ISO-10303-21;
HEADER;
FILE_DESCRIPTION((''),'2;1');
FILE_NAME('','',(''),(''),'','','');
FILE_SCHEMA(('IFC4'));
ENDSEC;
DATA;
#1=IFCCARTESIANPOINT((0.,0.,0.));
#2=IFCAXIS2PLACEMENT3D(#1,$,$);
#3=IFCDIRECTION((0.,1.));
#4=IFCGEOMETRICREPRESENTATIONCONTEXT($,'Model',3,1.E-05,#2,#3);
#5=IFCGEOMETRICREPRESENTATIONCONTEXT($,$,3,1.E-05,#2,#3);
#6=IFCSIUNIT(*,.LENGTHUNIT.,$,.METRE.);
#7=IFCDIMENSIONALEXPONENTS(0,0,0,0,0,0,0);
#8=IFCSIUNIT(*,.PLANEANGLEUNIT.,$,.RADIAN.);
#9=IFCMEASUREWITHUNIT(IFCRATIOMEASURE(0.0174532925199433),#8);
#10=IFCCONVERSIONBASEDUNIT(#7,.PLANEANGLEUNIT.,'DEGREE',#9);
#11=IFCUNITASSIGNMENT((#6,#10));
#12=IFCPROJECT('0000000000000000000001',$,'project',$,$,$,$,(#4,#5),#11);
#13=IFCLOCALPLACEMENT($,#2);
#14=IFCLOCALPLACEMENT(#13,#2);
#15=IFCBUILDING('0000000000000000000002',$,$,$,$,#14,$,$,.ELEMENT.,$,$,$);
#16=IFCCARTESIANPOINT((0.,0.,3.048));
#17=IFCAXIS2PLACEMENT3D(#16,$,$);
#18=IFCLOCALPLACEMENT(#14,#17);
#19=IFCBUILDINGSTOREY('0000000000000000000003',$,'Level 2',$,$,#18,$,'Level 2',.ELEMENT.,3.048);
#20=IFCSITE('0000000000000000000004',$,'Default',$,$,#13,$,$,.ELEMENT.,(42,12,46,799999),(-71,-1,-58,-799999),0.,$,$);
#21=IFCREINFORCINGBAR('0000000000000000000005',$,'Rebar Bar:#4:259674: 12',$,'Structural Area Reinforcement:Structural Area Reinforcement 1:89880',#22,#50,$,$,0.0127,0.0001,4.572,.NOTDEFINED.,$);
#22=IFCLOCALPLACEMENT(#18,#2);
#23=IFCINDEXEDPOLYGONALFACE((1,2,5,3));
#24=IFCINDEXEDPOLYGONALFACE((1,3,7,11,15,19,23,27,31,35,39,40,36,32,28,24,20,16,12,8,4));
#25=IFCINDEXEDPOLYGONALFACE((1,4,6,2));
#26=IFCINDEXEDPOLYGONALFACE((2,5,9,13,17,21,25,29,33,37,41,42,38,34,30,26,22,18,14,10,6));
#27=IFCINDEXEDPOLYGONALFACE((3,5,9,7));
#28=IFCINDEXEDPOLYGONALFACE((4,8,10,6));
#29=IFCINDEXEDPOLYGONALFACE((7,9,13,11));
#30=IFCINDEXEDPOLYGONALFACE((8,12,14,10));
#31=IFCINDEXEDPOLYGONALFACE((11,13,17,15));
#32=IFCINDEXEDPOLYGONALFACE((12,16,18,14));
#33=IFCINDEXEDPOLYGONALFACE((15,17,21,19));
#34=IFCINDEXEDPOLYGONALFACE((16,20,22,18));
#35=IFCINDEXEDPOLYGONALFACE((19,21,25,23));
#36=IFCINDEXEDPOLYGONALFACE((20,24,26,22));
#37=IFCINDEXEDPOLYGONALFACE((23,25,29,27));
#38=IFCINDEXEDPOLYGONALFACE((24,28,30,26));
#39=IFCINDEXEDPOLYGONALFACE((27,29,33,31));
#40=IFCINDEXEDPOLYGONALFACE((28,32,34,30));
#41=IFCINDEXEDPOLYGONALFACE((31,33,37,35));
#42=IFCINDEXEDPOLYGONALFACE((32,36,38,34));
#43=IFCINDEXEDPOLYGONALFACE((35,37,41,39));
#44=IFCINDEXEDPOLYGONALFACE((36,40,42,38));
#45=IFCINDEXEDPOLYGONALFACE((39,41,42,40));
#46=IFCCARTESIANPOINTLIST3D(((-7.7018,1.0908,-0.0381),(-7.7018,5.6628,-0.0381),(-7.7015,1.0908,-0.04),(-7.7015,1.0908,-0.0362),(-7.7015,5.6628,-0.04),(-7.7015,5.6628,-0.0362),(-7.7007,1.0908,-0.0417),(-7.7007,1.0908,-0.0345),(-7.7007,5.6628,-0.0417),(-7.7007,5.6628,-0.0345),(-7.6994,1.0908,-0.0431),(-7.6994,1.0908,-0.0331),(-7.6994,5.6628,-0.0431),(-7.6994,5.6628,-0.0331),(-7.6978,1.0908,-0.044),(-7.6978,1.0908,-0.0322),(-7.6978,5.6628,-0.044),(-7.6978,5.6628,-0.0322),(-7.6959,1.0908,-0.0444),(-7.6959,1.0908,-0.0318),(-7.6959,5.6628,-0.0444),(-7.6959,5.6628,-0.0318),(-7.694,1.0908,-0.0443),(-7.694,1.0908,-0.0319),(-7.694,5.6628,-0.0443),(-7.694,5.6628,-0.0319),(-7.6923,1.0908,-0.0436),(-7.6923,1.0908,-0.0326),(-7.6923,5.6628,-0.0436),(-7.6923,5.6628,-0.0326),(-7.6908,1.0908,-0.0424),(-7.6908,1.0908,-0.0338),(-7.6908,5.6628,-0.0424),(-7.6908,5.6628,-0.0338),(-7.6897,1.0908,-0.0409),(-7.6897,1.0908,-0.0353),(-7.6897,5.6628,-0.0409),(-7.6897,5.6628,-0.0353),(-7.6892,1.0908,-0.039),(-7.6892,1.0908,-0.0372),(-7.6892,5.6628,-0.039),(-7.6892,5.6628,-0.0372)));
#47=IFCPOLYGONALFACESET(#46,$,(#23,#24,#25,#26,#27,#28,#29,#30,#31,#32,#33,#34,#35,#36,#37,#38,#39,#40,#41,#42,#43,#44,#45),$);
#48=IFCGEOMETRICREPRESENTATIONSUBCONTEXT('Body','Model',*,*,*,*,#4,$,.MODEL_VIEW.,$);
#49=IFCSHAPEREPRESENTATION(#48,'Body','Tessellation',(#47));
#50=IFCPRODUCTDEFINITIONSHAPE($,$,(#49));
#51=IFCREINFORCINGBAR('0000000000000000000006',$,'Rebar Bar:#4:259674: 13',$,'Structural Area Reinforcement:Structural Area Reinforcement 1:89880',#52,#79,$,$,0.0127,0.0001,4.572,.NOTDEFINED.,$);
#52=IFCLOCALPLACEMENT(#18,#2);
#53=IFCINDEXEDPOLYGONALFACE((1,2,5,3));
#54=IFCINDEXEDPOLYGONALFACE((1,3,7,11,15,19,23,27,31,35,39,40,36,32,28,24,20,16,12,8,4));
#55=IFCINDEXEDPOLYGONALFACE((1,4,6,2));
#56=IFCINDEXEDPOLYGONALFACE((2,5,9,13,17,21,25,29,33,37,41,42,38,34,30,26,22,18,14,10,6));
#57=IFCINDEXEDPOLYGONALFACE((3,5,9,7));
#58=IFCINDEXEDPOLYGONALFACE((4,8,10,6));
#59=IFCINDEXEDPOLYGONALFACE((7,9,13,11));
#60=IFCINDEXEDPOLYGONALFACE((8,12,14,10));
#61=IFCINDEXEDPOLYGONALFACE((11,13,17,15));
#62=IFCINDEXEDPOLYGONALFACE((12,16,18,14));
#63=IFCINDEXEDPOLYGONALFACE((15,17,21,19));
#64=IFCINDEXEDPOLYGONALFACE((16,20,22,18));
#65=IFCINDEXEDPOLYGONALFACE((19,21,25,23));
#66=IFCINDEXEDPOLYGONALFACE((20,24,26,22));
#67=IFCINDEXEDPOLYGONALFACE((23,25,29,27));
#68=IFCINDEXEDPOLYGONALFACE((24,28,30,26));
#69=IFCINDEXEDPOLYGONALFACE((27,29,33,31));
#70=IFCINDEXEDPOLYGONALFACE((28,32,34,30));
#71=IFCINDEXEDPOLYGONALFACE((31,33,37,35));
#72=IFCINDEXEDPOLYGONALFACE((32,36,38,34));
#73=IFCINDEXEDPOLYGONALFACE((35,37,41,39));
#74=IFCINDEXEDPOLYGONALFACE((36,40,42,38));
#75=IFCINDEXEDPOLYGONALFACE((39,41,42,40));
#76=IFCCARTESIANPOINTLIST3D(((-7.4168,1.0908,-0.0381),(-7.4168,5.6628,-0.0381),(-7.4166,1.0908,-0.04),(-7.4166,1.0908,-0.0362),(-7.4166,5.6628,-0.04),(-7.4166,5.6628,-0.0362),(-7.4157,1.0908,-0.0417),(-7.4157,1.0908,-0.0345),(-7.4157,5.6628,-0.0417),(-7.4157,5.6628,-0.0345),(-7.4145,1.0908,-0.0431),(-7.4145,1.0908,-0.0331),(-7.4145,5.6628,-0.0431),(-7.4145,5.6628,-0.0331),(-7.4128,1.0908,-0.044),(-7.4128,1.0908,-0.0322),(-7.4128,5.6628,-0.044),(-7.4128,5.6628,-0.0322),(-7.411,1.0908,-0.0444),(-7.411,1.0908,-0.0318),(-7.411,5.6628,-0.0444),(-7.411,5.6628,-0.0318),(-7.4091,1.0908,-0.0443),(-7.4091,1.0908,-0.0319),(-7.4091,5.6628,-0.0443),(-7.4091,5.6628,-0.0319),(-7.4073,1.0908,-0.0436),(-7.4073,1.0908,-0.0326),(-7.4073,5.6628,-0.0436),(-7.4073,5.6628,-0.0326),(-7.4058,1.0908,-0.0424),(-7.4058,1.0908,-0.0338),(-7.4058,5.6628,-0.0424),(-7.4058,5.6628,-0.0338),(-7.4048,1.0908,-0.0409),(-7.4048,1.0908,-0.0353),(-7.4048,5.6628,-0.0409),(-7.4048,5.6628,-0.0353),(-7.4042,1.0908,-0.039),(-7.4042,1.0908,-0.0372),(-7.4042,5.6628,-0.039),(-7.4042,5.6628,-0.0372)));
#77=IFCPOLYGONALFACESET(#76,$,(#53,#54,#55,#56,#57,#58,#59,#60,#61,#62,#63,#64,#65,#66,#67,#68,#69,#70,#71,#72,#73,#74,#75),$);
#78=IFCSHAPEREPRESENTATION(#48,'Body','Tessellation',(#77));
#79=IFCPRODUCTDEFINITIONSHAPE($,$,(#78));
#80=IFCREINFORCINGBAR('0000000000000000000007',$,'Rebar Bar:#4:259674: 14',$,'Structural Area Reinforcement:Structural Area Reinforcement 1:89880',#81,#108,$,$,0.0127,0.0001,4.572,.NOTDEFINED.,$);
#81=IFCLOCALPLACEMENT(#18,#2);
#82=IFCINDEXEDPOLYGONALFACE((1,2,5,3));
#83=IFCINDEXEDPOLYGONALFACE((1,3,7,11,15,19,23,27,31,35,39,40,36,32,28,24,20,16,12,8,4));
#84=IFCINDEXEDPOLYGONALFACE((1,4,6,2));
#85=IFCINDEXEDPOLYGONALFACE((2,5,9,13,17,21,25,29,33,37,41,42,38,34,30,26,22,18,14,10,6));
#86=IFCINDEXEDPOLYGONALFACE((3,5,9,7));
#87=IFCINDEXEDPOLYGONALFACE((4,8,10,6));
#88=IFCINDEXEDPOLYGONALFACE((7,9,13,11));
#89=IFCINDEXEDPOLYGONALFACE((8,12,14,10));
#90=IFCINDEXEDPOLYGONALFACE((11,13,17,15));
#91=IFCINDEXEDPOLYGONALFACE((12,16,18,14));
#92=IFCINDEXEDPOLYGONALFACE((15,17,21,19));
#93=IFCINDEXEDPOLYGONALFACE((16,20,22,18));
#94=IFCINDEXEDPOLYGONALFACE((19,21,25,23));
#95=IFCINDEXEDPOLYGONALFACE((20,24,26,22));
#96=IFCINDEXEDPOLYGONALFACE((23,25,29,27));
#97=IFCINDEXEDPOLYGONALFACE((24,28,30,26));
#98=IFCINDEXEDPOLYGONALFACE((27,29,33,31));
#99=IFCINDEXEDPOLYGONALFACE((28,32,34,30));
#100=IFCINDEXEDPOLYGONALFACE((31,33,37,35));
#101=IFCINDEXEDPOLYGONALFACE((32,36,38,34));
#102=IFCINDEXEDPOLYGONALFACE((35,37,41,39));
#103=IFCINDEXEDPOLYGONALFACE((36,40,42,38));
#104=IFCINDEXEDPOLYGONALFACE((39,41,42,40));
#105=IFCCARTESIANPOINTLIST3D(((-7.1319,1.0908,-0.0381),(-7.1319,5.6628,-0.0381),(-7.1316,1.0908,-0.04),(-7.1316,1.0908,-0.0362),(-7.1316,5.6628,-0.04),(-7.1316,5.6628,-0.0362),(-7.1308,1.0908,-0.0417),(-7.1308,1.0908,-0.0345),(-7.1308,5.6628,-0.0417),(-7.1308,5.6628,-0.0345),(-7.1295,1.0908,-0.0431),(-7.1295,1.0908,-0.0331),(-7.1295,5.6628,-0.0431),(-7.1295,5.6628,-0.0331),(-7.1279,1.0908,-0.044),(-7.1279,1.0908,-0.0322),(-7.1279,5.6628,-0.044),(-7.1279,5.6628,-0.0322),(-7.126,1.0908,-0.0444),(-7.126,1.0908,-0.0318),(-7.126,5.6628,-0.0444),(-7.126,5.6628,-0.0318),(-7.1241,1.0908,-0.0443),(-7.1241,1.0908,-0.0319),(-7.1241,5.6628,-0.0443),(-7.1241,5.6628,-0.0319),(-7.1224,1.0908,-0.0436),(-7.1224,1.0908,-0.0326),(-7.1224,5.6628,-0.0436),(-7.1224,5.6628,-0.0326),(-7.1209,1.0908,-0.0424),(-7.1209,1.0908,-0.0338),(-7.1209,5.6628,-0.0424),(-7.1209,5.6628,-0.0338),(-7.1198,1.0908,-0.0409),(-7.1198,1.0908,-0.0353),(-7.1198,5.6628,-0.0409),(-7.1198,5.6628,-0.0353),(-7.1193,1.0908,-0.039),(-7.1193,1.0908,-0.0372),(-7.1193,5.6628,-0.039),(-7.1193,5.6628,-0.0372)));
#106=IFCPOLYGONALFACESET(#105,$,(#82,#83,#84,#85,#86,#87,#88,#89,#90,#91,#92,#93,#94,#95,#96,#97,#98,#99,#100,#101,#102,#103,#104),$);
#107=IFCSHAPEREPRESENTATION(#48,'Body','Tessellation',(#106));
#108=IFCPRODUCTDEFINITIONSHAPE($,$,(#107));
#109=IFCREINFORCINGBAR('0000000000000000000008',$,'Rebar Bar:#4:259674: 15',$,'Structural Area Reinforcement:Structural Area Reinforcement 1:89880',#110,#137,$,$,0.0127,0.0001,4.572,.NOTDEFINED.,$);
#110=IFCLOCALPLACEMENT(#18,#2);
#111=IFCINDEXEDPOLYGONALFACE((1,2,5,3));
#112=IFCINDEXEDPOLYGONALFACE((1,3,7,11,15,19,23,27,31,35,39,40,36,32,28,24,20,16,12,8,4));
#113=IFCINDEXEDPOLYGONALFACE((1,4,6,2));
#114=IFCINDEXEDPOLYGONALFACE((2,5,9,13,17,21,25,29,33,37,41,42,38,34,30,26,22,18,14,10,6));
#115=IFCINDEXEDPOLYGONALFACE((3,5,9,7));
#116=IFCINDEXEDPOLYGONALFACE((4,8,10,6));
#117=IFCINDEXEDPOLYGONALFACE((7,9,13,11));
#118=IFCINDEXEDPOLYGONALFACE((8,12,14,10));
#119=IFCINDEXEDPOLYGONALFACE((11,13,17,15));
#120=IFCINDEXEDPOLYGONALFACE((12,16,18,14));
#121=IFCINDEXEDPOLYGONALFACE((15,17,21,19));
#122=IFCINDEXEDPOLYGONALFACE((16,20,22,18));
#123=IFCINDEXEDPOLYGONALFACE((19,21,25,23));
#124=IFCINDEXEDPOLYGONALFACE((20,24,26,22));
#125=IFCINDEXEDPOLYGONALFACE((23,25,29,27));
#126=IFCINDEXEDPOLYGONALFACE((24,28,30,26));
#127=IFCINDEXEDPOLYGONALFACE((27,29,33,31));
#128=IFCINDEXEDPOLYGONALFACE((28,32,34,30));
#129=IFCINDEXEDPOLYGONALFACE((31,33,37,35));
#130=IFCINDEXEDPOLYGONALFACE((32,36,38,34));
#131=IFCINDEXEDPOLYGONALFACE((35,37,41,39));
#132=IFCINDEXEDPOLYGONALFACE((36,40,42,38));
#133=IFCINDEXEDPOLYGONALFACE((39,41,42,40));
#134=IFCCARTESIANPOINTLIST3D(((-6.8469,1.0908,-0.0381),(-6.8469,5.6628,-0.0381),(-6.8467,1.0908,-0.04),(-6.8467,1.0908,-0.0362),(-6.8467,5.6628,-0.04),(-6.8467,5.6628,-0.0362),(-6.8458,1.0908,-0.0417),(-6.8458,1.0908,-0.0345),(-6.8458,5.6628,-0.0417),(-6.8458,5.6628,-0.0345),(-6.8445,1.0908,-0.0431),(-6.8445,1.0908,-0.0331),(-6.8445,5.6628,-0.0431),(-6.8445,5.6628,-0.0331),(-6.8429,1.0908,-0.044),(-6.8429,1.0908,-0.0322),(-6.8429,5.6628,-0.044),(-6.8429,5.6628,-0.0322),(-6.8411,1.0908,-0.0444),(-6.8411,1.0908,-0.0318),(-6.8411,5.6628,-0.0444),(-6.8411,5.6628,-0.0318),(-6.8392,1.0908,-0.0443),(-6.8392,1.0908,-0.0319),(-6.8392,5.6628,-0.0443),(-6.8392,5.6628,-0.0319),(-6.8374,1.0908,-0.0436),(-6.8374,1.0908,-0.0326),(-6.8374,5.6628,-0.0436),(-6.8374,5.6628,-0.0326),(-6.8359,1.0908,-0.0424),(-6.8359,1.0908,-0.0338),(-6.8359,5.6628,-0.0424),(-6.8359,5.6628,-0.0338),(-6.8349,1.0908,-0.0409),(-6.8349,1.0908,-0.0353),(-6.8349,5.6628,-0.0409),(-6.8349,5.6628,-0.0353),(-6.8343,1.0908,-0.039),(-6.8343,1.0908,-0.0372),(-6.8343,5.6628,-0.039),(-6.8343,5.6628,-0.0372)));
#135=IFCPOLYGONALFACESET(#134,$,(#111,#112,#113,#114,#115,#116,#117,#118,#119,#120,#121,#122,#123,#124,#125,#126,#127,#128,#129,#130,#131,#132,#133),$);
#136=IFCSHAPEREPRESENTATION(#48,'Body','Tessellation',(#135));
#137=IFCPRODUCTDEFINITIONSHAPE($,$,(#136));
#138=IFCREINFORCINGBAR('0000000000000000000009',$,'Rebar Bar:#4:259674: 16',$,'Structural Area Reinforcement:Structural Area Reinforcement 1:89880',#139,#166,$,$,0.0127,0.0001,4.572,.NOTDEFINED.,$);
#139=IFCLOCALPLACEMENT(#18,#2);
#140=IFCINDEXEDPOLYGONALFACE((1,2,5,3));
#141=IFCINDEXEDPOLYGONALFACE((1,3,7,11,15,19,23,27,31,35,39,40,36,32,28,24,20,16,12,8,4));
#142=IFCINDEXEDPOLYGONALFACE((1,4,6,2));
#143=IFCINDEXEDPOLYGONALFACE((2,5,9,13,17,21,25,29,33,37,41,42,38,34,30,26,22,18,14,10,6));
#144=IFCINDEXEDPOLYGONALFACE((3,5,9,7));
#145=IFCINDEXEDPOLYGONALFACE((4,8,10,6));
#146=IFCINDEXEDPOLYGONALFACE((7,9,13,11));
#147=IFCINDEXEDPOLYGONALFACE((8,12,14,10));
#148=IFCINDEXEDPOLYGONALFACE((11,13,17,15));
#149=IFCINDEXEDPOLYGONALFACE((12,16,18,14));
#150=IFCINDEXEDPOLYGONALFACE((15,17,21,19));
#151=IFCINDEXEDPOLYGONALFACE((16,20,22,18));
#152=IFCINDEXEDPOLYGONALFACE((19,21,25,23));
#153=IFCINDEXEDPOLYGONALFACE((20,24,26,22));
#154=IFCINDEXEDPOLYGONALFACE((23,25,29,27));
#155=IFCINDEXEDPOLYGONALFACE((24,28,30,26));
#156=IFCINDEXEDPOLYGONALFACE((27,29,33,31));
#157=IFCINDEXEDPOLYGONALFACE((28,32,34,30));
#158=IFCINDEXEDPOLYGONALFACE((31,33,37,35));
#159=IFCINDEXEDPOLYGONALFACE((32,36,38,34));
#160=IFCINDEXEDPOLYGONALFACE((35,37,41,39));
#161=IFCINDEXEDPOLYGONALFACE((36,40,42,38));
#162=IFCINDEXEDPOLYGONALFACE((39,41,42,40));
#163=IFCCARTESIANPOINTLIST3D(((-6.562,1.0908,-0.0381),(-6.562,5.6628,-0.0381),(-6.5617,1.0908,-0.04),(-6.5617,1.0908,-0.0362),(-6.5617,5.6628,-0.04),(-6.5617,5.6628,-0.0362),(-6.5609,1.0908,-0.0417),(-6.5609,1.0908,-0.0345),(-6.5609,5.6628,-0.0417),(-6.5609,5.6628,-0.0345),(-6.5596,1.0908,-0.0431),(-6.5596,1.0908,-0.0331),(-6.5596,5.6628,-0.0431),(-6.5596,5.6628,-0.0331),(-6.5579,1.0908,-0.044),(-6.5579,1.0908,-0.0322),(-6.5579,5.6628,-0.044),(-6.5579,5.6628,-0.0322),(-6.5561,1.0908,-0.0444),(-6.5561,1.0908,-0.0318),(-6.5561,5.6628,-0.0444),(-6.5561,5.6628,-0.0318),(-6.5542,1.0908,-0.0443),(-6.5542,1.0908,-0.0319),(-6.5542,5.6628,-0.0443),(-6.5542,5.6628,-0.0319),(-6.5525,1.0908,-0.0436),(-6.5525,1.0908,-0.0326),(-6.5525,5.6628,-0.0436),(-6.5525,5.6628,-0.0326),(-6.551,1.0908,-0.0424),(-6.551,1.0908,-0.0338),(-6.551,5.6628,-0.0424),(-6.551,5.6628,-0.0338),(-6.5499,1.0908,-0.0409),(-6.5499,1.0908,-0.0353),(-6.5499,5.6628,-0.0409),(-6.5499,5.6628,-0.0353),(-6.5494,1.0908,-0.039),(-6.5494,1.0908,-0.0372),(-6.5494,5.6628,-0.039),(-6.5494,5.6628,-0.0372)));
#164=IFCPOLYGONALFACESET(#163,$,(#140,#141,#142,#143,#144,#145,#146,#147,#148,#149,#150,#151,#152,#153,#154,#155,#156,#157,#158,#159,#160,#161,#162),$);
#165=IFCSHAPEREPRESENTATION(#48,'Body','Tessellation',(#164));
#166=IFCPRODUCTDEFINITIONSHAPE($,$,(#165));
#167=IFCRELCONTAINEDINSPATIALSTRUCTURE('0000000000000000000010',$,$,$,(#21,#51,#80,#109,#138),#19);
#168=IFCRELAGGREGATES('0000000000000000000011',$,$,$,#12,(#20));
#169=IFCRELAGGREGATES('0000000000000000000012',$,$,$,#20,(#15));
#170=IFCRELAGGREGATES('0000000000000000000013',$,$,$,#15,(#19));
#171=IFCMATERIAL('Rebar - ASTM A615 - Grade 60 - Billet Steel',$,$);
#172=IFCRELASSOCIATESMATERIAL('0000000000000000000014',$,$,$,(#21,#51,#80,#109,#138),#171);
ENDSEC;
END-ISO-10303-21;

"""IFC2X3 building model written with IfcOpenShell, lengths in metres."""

from ifc_helpers import new_model, entity, si_unit, converted_unit, direction, frame, origin, place, context, subcontext, project, spatial, material, element, save


model = new_model("IFC2X3")

# Units and contexts
model_context = context("Model", 3, precision=1e-05, world=origin(), true_north=direction((0.0, 1.0)))
context_of_model = context(None, 3, precision=1e-05, world=origin(), true_north=direction((0.0, 1.0)))
body_context = subcontext(model_context, "Body", "Model", "MODEL_VIEW")
ifc_project = project(units=[si_unit("LENGTHUNIT", "METRE"), converted_unit("PLANEANGLEUNIT", "DEGREE", entity("IfcRatioMeasure", 0.0174532925199433), si_unit("PLANEANGLEUNIT", "RADIAN"), dimensions=[0, 0, 0, 0, 0, 0, 0])], contexts=[model_context, context_of_model])

# Site, building, storey
site_placement = place(None, origin())
site = spatial("IfcSite", under=ifc_project, at=site_placement, Name="Default", CompositionType="ELEMENT", RefLatitude=(42, 12, 46, 799999), RefLongitude=(-71, -1, -58, -799999), RefElevation=0.0)
building_placement = place(site_placement, origin())
building = spatial("IfcBuilding", under=site, at=building_placement, CompositionType="ELEMENT")
storey_placement = place(building_placement, frame((0.0, 0.0, 3.048)))
storey = spatial("IfcBuildingStorey", under=building, at=storey_placement, Name="Level 2", LongName="Level 2", CompositionType="ELEMENT", Elevation=3.048)

# Reinforcing bars
ifc_material_1 = material(Name="Rebar - ASTM A615 - Grade 60 - Billet Steel")
reinforcing_bar_1_placement = place(storey_placement, origin())
element("IfcReinforcingBar", 1, at=reinforcing_bar_1_placement, inside=storey, material=ifc_material_1, Name="Rebar Bar:#4:259674: 12", ObjectType="Structural Area Reinforcement:Structural Area Reinforcement 1:89880", BarLength=4.572, BarRole="NOTDEFINED", CrossSectionArea=0.0001, NominalDiameter=0.0127, context=body_context, shape_type="AdvancedSweptSolid", body=[
    entity("IfcSweptDiskSolid", entity("IfcCompositeCurve", [entity("IfcCompositeCurveSegment", "CONTINUOUS", True, entity("IfcPolyline", [entity("IfcCartesianPoint", [-7.6955, 5.6628, -0.0381]), entity("IfcCartesianPoint", [-7.6955, 1.0908, -0.0381])]))], False), 0.0063, None, 0.0, 1.0),
])
reinforcing_bar_2_placement = place(storey_placement, origin())
element("IfcReinforcingBar", 2, at=reinforcing_bar_2_placement, inside=storey, material=ifc_material_1, Name="Rebar Bar:#4:259674: 13", ObjectType="Structural Area Reinforcement:Structural Area Reinforcement 1:89880", BarLength=4.572, BarRole="NOTDEFINED", CrossSectionArea=0.0001, NominalDiameter=0.0127, context=body_context, shape_type="AdvancedSweptSolid", body=[
    entity("IfcSweptDiskSolid", entity("IfcCompositeCurve", [entity("IfcCompositeCurveSegment", "CONTINUOUS", True, entity("IfcPolyline", [entity("IfcCartesianPoint", [-7.4105, 5.6628, -0.0381]), entity("IfcCartesianPoint", [-7.4105, 1.0908, -0.0381])]))], False), 0.0063, None, 0.0, 1.0),
])
reinforcing_bar_3_placement = place(storey_placement, origin())
element("IfcReinforcingBar", 3, at=reinforcing_bar_3_placement, inside=storey, material=ifc_material_1, Name="Rebar Bar:#4:259674: 14", ObjectType="Structural Area Reinforcement:Structural Area Reinforcement 1:89880", BarLength=4.572, BarRole="NOTDEFINED", CrossSectionArea=0.0001, NominalDiameter=0.0127, context=body_context, shape_type="AdvancedSweptSolid", body=[
    entity("IfcSweptDiskSolid", entity("IfcCompositeCurve", [entity("IfcCompositeCurveSegment", "CONTINUOUS", True, entity("IfcPolyline", [entity("IfcCartesianPoint", [-7.1255, 5.6628, -0.0381]), entity("IfcCartesianPoint", [-7.1255, 1.0908, -0.0381])]))], False), 0.0063, None, 0.0, 1.0),
])
reinforcing_bar_4_placement = place(storey_placement, origin())
element("IfcReinforcingBar", 4, at=reinforcing_bar_4_placement, inside=storey, material=ifc_material_1, Name="Rebar Bar:#4:259674: 15", ObjectType="Structural Area Reinforcement:Structural Area Reinforcement 1:89880", BarLength=4.572, BarRole="NOTDEFINED", CrossSectionArea=0.0001, NominalDiameter=0.0127, context=body_context, shape_type="AdvancedSweptSolid", body=[
    entity("IfcSweptDiskSolid", entity("IfcCompositeCurve", [entity("IfcCompositeCurveSegment", "CONTINUOUS", True, entity("IfcPolyline", [entity("IfcCartesianPoint", [-6.8406, 5.6628, -0.0381]), entity("IfcCartesianPoint", [-6.8406, 1.0908, -0.0381])]))], False), 0.0063, None, 0.0, 1.0),
])
reinforcing_bar_5_placement = place(storey_placement, origin())
element("IfcReinforcingBar", 5, at=reinforcing_bar_5_placement, inside=storey, material=ifc_material_1, Name="Rebar Bar:#4:259674: 16", ObjectType="Structural Area Reinforcement:Structural Area Reinforcement 1:89880", BarLength=4.572, BarRole="NOTDEFINED", CrossSectionArea=0.0001, NominalDiameter=0.0127, context=body_context, shape_type="AdvancedSweptSolid", body=[
    entity("IfcSweptDiskSolid", entity("IfcCompositeCurve", [entity("IfcCompositeCurveSegment", "CONTINUOUS", True, entity("IfcPolyline", [entity("IfcCartesianPoint", [-6.5556, 5.6628, -0.0381]), entity("IfcCartesianPoint", [-6.5556, 1.0908, -0.0381])]))], False), 0.0063, None, 0.0, 1.0),
])

save(model, "model.ifc")
